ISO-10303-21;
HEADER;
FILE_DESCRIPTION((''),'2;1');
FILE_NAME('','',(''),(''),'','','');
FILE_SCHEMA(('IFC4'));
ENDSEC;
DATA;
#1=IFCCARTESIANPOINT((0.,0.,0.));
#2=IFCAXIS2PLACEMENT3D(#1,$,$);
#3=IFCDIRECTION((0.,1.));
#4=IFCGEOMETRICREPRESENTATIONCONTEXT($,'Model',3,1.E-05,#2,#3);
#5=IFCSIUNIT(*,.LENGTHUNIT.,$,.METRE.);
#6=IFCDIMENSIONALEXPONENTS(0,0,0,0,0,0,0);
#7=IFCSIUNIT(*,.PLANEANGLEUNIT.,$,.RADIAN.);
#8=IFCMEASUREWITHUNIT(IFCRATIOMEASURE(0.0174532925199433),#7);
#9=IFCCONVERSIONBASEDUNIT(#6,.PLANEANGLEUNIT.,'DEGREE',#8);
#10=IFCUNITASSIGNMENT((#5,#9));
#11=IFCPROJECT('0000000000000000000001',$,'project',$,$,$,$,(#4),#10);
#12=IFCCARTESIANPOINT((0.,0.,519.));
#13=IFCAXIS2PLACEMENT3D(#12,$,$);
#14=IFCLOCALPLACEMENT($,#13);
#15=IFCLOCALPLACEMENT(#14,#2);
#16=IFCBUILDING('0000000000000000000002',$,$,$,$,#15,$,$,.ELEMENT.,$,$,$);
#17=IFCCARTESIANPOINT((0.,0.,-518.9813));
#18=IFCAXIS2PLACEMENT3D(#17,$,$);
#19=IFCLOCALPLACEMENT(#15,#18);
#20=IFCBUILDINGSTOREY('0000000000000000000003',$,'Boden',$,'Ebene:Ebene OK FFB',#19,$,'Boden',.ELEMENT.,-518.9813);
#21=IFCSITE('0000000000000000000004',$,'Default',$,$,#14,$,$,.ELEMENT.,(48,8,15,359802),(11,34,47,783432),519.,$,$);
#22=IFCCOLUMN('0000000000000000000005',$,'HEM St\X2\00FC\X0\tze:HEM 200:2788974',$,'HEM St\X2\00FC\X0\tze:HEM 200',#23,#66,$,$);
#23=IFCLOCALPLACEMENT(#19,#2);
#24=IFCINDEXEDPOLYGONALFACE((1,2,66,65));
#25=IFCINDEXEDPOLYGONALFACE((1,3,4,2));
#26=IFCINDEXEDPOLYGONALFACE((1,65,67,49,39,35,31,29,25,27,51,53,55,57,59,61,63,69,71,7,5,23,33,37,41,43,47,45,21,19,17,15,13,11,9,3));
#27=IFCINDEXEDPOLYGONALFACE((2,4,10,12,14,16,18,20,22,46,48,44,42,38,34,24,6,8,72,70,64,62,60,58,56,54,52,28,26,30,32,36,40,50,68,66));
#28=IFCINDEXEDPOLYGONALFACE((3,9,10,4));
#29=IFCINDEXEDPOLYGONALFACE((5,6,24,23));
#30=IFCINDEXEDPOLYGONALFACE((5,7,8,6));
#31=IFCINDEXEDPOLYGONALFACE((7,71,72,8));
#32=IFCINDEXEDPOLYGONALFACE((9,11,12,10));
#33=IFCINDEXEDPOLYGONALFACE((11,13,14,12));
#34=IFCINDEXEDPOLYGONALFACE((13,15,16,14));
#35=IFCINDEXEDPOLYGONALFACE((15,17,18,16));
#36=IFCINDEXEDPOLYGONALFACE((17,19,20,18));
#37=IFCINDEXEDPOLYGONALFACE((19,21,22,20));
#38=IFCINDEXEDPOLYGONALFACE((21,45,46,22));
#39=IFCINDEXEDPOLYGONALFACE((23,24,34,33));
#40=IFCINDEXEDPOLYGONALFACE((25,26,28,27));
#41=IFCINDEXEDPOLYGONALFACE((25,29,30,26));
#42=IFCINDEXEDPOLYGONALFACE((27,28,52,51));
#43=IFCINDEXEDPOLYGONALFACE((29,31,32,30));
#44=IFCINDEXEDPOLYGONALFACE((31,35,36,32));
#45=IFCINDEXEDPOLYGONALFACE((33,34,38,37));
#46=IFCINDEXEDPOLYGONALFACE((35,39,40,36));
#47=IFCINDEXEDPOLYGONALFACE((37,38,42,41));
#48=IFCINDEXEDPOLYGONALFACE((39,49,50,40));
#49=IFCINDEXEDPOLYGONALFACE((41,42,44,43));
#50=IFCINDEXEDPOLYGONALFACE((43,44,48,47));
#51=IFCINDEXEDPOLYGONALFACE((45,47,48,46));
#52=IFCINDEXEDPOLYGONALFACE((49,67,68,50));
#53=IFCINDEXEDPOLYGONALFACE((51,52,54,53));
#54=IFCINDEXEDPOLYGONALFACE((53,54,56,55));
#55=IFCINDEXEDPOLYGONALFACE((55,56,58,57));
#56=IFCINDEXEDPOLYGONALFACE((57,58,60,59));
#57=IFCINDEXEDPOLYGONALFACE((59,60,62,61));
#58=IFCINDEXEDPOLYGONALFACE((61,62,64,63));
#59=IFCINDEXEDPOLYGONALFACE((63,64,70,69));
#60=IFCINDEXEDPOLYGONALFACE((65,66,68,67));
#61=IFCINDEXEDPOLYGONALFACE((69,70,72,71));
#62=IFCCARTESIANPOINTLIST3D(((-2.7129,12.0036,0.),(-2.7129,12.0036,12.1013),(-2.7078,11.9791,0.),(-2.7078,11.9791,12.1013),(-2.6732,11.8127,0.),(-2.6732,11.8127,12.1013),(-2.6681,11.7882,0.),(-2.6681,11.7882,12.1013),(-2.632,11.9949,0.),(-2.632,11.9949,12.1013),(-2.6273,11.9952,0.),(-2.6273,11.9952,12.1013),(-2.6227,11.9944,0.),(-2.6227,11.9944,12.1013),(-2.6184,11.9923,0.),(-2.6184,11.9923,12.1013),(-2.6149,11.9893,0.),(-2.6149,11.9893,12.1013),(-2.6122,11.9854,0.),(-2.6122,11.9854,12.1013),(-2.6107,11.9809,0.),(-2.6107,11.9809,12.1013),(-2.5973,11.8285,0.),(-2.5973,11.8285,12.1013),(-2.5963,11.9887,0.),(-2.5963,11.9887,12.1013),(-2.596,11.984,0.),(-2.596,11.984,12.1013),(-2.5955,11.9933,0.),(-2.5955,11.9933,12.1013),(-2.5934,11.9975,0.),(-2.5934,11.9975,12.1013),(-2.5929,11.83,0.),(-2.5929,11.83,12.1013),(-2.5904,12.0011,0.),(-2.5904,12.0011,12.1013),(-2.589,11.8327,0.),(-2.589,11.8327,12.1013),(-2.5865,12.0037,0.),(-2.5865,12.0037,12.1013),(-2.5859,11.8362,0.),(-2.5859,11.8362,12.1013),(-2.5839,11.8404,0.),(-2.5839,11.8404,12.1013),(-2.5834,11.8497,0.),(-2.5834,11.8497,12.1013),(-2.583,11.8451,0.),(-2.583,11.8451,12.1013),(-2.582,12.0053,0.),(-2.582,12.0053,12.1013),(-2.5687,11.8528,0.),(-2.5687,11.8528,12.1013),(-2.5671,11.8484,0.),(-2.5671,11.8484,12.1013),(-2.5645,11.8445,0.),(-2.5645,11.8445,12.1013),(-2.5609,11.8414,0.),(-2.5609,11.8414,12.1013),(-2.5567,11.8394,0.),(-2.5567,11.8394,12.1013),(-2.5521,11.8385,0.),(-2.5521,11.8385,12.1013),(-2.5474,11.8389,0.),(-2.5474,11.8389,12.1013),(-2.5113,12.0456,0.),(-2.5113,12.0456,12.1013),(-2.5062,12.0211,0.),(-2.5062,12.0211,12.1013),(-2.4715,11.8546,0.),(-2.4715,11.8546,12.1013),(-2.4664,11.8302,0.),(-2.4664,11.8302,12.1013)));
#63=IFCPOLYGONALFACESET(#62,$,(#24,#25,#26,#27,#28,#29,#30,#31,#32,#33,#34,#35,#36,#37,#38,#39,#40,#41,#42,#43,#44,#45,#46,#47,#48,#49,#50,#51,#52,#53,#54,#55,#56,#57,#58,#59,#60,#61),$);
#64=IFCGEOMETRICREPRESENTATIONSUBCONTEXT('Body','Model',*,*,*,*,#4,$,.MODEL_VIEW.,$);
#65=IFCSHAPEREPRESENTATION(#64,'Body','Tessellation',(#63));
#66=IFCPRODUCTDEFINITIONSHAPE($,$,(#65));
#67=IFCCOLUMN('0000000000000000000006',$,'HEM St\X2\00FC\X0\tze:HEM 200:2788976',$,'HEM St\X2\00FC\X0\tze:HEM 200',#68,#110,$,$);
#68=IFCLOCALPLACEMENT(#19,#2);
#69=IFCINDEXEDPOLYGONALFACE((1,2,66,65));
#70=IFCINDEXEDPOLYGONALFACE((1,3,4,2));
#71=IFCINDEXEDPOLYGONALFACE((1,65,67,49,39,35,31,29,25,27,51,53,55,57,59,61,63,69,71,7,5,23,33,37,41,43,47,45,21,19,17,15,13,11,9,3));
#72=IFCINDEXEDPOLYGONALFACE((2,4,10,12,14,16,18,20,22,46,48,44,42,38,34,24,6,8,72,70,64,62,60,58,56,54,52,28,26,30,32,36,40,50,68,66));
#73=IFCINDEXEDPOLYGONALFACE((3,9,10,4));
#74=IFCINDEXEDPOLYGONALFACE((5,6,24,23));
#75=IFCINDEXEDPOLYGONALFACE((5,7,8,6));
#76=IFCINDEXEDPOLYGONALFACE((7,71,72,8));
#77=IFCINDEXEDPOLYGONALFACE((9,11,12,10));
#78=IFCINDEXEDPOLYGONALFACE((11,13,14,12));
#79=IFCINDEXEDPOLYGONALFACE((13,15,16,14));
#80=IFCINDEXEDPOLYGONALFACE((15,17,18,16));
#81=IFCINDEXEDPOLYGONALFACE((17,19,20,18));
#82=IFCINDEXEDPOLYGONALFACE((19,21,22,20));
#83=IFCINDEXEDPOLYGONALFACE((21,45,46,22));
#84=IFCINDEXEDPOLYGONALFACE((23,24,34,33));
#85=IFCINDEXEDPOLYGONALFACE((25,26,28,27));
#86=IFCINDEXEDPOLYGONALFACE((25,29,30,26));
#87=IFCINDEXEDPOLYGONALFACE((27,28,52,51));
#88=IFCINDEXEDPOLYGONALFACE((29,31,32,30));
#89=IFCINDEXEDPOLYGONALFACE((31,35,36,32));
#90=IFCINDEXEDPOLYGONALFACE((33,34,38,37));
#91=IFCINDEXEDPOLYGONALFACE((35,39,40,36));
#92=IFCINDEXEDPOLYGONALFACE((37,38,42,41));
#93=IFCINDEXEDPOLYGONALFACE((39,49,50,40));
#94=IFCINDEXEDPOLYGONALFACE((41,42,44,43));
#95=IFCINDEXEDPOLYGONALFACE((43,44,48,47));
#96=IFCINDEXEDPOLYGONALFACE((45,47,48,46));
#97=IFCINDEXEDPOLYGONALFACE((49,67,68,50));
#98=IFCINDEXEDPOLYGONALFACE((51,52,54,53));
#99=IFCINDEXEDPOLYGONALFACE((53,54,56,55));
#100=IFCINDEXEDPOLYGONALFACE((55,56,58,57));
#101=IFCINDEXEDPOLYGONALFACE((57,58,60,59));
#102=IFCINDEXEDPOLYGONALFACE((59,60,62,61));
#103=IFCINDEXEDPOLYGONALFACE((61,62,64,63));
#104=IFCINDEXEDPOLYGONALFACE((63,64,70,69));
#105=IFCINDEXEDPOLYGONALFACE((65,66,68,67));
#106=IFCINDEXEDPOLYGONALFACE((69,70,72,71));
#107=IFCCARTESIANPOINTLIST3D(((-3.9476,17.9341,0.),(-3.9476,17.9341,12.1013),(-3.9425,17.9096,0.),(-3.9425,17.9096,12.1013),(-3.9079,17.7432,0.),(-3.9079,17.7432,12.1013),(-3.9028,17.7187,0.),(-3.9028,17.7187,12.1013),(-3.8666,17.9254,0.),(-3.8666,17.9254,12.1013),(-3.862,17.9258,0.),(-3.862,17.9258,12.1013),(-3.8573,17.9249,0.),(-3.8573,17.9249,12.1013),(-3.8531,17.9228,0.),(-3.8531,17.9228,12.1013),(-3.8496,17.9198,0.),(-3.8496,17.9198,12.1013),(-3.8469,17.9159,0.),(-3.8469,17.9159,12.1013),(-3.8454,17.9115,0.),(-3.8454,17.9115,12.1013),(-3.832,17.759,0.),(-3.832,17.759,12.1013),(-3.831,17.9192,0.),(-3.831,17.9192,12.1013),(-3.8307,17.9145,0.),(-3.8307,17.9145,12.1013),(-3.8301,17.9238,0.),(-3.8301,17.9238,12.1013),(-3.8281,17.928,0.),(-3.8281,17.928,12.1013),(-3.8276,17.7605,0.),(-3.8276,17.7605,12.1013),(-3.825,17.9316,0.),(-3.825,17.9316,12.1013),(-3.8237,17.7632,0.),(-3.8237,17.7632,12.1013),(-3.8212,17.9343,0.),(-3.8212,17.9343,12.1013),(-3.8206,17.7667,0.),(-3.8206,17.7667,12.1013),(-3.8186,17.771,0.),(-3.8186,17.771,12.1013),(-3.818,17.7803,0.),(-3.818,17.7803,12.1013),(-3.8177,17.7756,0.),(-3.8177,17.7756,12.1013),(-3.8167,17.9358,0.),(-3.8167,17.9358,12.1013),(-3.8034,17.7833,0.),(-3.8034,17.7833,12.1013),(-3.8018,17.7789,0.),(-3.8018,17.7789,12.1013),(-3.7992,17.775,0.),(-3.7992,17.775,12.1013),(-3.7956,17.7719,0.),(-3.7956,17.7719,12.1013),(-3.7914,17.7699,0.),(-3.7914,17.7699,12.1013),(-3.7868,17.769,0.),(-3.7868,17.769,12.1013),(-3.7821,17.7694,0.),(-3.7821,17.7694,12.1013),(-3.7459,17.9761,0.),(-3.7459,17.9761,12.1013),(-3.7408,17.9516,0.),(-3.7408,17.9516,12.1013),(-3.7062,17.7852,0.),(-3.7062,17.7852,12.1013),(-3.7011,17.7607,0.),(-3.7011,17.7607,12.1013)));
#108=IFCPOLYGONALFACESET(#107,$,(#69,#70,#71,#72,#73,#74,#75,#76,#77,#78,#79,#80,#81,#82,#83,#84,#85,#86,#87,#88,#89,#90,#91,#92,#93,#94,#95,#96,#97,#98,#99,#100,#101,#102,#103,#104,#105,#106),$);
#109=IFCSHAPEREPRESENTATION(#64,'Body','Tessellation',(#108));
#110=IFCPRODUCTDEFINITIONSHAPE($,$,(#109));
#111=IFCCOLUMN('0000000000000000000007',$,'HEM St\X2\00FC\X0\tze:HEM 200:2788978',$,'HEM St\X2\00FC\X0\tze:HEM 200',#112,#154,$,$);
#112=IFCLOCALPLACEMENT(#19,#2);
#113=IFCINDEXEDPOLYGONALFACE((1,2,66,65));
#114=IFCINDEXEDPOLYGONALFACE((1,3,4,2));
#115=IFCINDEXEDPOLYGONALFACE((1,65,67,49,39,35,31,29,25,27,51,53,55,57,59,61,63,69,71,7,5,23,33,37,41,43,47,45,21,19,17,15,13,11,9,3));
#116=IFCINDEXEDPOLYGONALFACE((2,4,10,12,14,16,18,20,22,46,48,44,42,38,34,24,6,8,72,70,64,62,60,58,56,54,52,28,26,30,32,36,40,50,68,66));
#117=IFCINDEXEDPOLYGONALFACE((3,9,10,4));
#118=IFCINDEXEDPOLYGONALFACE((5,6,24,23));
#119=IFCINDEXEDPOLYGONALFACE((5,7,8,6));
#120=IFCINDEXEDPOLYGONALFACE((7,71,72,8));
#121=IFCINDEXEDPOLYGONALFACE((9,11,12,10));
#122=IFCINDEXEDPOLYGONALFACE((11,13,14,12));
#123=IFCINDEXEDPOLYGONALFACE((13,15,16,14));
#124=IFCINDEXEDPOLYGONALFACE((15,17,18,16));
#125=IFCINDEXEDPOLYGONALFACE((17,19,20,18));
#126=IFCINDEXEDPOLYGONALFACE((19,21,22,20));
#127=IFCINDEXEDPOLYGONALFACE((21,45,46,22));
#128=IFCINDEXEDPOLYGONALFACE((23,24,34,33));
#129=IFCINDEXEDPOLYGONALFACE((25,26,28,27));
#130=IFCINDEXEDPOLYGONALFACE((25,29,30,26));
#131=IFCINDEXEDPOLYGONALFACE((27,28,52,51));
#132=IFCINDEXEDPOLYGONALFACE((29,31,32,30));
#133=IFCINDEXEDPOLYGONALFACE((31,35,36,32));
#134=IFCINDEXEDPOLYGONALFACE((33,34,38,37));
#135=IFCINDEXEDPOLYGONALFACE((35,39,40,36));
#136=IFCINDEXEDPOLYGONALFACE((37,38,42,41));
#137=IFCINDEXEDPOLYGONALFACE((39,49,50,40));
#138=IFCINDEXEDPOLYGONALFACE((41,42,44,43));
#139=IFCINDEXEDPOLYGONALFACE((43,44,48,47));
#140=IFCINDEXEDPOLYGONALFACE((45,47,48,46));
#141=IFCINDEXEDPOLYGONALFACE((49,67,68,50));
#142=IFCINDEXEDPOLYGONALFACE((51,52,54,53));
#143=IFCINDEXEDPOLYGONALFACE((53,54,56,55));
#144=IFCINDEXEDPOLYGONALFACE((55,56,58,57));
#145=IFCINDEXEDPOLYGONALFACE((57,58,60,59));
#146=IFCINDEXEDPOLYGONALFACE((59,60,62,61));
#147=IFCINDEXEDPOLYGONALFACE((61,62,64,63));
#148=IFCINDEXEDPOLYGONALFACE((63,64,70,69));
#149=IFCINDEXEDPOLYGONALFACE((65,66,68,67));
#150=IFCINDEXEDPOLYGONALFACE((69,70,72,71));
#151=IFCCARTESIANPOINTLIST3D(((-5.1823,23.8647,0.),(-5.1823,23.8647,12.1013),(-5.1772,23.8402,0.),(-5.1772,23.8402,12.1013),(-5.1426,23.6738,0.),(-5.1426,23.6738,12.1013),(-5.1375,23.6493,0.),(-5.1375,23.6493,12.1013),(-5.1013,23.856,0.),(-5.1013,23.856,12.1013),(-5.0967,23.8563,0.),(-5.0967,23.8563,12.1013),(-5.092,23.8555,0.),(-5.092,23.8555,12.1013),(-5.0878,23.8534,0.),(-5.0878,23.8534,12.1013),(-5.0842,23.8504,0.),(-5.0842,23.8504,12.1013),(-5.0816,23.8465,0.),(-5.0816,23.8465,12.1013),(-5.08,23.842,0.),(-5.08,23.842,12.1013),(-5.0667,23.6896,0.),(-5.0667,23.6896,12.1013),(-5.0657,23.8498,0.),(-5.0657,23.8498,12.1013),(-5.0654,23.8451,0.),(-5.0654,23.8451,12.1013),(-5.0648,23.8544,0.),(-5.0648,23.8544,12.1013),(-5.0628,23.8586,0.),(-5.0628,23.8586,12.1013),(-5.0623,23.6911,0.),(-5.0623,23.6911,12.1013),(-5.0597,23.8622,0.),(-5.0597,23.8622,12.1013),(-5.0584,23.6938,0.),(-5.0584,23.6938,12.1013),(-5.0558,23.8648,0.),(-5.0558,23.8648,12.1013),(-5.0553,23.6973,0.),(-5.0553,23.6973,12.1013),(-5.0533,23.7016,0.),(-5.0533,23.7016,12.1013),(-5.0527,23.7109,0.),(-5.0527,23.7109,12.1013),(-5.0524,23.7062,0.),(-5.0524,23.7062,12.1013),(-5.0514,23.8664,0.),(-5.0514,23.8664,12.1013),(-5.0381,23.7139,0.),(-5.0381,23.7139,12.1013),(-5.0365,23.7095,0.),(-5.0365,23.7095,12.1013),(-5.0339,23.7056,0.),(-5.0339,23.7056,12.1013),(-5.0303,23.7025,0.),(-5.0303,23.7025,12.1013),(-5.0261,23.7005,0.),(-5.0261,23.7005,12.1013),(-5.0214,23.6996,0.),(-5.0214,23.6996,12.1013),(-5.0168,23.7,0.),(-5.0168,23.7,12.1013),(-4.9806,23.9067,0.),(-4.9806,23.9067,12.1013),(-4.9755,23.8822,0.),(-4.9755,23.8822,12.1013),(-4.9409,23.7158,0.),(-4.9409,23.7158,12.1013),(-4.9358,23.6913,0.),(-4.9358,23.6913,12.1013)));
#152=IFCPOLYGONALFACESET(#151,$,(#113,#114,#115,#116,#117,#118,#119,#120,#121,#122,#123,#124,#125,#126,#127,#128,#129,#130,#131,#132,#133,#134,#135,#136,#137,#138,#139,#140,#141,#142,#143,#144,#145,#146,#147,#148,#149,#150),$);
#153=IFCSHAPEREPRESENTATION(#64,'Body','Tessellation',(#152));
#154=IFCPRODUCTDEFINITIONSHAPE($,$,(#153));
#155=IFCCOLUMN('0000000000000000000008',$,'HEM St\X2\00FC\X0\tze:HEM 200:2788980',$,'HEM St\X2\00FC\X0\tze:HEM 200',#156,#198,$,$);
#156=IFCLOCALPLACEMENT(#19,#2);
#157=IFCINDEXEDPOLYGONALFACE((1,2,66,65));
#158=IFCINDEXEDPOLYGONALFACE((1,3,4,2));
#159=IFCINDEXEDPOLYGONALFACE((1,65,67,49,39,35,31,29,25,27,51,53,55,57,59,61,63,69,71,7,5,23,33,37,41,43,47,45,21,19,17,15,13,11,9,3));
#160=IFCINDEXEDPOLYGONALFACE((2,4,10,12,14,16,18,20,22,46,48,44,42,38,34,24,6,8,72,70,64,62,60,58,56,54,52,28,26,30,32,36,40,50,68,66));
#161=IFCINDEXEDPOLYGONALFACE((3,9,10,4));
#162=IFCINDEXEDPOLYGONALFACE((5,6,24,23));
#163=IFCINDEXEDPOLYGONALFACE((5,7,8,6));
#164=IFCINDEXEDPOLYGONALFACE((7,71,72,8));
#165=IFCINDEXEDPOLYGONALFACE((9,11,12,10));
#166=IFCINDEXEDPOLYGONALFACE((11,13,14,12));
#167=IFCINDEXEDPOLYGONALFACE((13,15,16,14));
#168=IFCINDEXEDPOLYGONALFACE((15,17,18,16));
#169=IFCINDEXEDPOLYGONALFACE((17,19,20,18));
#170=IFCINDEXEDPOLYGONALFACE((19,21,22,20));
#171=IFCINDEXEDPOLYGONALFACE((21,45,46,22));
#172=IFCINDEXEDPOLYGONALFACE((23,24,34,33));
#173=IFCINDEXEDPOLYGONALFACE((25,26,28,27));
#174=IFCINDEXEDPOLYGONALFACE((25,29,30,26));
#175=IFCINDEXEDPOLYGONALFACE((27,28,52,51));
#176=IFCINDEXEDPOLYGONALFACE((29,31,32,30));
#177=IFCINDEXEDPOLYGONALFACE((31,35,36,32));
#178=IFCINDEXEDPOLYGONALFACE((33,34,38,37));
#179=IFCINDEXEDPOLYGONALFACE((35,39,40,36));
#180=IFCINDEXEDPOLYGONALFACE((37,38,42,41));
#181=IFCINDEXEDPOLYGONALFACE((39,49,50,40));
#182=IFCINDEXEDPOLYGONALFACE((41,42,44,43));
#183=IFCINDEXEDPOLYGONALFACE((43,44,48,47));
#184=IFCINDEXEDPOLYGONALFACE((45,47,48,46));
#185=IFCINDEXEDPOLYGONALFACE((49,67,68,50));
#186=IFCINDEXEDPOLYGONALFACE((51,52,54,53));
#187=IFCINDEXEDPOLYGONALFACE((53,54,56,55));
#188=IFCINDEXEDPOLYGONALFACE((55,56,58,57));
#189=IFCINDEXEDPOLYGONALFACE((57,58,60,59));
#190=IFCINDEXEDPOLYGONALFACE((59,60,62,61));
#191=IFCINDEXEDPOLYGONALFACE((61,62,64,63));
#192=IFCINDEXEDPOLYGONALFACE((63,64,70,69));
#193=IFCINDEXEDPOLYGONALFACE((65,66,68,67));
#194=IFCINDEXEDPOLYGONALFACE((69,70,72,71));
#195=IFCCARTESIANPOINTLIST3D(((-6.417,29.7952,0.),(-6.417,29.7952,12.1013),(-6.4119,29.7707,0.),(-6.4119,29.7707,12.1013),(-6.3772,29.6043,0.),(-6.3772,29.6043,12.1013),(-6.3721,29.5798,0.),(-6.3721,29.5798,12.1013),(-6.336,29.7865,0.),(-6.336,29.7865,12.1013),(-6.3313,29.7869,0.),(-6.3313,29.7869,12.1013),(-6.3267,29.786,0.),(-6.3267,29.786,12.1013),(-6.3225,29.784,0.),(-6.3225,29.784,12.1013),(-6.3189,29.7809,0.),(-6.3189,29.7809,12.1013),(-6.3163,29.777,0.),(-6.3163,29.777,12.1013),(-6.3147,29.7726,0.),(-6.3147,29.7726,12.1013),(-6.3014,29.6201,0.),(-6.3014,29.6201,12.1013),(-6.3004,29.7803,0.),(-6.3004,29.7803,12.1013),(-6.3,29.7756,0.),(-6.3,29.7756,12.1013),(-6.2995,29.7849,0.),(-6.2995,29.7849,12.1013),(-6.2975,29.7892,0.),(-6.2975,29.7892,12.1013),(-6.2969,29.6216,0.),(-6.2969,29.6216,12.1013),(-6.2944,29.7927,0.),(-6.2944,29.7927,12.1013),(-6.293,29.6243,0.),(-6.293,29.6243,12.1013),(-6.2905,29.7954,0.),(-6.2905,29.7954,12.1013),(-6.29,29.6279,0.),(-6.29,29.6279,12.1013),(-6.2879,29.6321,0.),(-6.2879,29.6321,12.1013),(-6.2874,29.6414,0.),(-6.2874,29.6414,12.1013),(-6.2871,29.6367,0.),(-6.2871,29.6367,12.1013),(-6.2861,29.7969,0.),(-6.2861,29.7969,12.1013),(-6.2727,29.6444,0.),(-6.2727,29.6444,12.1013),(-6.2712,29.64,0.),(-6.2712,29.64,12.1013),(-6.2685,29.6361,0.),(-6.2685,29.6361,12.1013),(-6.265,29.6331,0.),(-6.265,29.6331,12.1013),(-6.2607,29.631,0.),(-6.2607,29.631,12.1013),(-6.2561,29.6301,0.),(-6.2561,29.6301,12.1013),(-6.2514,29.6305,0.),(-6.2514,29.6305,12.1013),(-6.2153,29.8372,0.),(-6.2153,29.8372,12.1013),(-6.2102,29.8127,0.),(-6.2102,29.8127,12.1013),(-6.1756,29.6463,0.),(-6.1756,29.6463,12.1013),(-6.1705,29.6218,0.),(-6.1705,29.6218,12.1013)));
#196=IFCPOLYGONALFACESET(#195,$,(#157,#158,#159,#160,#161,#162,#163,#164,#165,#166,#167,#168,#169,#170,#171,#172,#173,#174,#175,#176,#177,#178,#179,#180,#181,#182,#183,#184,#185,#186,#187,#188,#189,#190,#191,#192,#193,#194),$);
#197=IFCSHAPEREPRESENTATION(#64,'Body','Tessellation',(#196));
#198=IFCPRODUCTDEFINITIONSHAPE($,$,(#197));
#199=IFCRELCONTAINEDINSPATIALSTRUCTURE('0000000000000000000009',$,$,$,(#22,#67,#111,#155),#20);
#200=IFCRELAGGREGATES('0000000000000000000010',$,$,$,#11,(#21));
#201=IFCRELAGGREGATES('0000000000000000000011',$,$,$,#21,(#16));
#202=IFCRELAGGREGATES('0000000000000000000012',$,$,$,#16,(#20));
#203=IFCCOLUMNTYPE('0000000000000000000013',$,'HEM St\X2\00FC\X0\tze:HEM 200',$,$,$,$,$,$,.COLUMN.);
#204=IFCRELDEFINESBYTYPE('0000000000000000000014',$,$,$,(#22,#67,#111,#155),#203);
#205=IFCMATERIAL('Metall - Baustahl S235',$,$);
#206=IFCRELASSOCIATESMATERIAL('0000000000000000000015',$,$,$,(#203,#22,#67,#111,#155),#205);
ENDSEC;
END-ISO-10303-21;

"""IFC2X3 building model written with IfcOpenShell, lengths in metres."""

from ifc_helpers import new_model, entity, si_unit, converted_unit, direction, frame, frame_2d, origin, place, context, subcontext, project, spatial, polyline, circle_curve, parameter, trimmed, segment, composite_curve, outline, extrude, source, transform, mapped, material, type_object, type_shapes, element, save


model = new_model("IFC2X3")

# Units and contexts
model_context = context("Model", 3, precision=1e-05, world=origin(), true_north=direction((0.0, 1.0)))
body_context = subcontext(model_context, "Body", "Model", "MODEL_VIEW")
ifc_project = project(units=[si_unit("LENGTHUNIT", "METRE"), converted_unit("PLANEANGLEUNIT", "DEGREE", entity("IfcRatioMeasure", 0.0174532925199433), si_unit("PLANEANGLEUNIT", "RADIAN"), dimensions=[0, 0, 0, 0, 0, 0, 0])], contexts=[model_context])

# Site, building, storey
site_placement = place(None, frame((0.0, 0.0, 519.0)))
site = spatial("IfcSite", under=ifc_project, at=site_placement, Name="Default", CompositionType="ELEMENT", RefLatitude=(48, 8, 15, 359802), RefLongitude=(11, 34, 47, 783432), RefElevation=519.0)
building_placement = place(site_placement, origin())
building = spatial("IfcBuilding", under=site, at=building_placement, CompositionType="ELEMENT")
storey_placement = place(building_placement, frame((0.0, 0.0, -518.9813)))
storey = spatial("IfcBuildingStorey", under=building, at=storey_placement, Name="Boden", ObjectType="Ebene:Ebene OK FFB", LongName="Boden", CompositionType="ELEMENT", Elevation=-518.9813)

# Columns
ifc_material = material(Name="Metall - Baustahl S235")
column_type_1 = type_object("IfcColumnType", Name="HEM Stütze:HEM 200", PredefinedType="COLUMN", material=ifc_material)
shared_shape_1 = source(origin(), body_context, "Body", "SweptSolid", [
    extrude(outline(composite_curve([segment(polyline([(0.085, -0.103), (0.11, -0.103)]), True, "CONTINUOUS"), segment(polyline([(0.11, -0.103), (0.11, 0.103)]), True, "CONTINUOUS"), segment(polyline([(0.11, 0.103), (0.085, 0.103)]), True, "CONTINUOUS"), segment(polyline([(0.085, 0.103), (0.085, 0.0255)]), True, "CONTINUOUS"), segment(trimmed(circle_curve(frame_2d((0.067, 0.0255), x_axis=(1.0, 0.0)), 0.018), [parameter(270.0)], [parameter(0.0)], True, "PARAMETER"), False, "CONTINUOUS"), segment(polyline([(0.067, 0.0075), (-0.067, 0.0075)]), True, "CONTINUOUS"), segment(trimmed(circle_curve(frame_2d((-0.067, 0.0255), x_axis=(0.0, -1.0)), 0.018), [parameter(270.0)], [parameter(0.0)], True, "PARAMETER"), False, "CONTINUOUS"), segment(polyline([(-0.085, 0.0255), (-0.085, 0.103)]), True, "CONTINUOUS"), segment(polyline([(-0.085, 0.103), (-0.11, 0.103)]), True, "CONTINUOUS"), segment(polyline([(-0.11, 0.103), (-0.11, -0.103)]), True, "CONTINUOUS"), segment(polyline([(-0.11, -0.103), (-0.085, -0.103)]), True, "CONTINUOUS"), segment(polyline([(-0.085, -0.103), (-0.085, -0.0255)]), True, "CONTINUOUS"), segment(trimmed(circle_curve(frame_2d((-0.067, -0.0255), x_axis=(-1.0, 0.0)), 0.018), [parameter(270.0)], [parameter(0.0)], True, "PARAMETER"), False, "CONTINUOUS"), segment(polyline([(-0.067, -0.0075), (0.067, -0.0075)]), True, "CONTINUOUS"), segment(trimmed(circle_curve(frame_2d((0.067, -0.0255), x_axis=(0.0, 1.0)), 0.018), [parameter(270.0)], [parameter(0.0)], True, "PARAMETER"), False, "CONTINUOUS"), segment(polyline([(0.085, -0.0255), (0.085, -0.103)]), True, "CONTINUOUS")], self_intersect=False)), frame((0.0, 0.0, -518.9813), z_axis=(0.0, 0.0, 1.0), x_axis=(0.0, -1.0, 0.0)), (0.0, 0.0, 1.0), 12.1013),
])
type_shapes(column_type_1, [shared_shape_1])
for number, where, z_axis, x_axis, name in (
    (1, (-2.5897, 11.9169, 518.9813), (0.0, 0.0, 1.0), (0.979008, 0.20382, 0.0), "HEM Stütze:HEM 200:2788974"),
    (2, (-3.8244, 17.8474, 518.9813), (0.0, 0.0, 1.0), (0.979008, 0.20382, 0.0), "HEM Stütze:HEM 200:2788976"),
    (3, (-5.059, 23.778, 518.9813), (0.0, 0.0, 1.0), (0.979008, 0.20382, 0.0), "HEM Stütze:HEM 200:2788978"),
    (4, (-6.2937, 29.7085, 518.9813), (0.0, 0.0, 1.0), (0.979008, 0.20382, 0.0), "HEM Stütze:HEM 200:2788980"),
):
    element("IfcColumn", number, at=place(storey_placement, frame(where, z_axis=z_axis, x_axis=x_axis)), inside=storey, type_object=column_type_1, material=ifc_material, Name=name, ObjectType="HEM Stütze:HEM 200", context=body_context, shape_type="MappedRepresentation", body=[
        mapped(shared_shape_1, transform((0.0, 0.0, 0.0), scale=1.0)),
    ])

save(model, "model.ifc")
